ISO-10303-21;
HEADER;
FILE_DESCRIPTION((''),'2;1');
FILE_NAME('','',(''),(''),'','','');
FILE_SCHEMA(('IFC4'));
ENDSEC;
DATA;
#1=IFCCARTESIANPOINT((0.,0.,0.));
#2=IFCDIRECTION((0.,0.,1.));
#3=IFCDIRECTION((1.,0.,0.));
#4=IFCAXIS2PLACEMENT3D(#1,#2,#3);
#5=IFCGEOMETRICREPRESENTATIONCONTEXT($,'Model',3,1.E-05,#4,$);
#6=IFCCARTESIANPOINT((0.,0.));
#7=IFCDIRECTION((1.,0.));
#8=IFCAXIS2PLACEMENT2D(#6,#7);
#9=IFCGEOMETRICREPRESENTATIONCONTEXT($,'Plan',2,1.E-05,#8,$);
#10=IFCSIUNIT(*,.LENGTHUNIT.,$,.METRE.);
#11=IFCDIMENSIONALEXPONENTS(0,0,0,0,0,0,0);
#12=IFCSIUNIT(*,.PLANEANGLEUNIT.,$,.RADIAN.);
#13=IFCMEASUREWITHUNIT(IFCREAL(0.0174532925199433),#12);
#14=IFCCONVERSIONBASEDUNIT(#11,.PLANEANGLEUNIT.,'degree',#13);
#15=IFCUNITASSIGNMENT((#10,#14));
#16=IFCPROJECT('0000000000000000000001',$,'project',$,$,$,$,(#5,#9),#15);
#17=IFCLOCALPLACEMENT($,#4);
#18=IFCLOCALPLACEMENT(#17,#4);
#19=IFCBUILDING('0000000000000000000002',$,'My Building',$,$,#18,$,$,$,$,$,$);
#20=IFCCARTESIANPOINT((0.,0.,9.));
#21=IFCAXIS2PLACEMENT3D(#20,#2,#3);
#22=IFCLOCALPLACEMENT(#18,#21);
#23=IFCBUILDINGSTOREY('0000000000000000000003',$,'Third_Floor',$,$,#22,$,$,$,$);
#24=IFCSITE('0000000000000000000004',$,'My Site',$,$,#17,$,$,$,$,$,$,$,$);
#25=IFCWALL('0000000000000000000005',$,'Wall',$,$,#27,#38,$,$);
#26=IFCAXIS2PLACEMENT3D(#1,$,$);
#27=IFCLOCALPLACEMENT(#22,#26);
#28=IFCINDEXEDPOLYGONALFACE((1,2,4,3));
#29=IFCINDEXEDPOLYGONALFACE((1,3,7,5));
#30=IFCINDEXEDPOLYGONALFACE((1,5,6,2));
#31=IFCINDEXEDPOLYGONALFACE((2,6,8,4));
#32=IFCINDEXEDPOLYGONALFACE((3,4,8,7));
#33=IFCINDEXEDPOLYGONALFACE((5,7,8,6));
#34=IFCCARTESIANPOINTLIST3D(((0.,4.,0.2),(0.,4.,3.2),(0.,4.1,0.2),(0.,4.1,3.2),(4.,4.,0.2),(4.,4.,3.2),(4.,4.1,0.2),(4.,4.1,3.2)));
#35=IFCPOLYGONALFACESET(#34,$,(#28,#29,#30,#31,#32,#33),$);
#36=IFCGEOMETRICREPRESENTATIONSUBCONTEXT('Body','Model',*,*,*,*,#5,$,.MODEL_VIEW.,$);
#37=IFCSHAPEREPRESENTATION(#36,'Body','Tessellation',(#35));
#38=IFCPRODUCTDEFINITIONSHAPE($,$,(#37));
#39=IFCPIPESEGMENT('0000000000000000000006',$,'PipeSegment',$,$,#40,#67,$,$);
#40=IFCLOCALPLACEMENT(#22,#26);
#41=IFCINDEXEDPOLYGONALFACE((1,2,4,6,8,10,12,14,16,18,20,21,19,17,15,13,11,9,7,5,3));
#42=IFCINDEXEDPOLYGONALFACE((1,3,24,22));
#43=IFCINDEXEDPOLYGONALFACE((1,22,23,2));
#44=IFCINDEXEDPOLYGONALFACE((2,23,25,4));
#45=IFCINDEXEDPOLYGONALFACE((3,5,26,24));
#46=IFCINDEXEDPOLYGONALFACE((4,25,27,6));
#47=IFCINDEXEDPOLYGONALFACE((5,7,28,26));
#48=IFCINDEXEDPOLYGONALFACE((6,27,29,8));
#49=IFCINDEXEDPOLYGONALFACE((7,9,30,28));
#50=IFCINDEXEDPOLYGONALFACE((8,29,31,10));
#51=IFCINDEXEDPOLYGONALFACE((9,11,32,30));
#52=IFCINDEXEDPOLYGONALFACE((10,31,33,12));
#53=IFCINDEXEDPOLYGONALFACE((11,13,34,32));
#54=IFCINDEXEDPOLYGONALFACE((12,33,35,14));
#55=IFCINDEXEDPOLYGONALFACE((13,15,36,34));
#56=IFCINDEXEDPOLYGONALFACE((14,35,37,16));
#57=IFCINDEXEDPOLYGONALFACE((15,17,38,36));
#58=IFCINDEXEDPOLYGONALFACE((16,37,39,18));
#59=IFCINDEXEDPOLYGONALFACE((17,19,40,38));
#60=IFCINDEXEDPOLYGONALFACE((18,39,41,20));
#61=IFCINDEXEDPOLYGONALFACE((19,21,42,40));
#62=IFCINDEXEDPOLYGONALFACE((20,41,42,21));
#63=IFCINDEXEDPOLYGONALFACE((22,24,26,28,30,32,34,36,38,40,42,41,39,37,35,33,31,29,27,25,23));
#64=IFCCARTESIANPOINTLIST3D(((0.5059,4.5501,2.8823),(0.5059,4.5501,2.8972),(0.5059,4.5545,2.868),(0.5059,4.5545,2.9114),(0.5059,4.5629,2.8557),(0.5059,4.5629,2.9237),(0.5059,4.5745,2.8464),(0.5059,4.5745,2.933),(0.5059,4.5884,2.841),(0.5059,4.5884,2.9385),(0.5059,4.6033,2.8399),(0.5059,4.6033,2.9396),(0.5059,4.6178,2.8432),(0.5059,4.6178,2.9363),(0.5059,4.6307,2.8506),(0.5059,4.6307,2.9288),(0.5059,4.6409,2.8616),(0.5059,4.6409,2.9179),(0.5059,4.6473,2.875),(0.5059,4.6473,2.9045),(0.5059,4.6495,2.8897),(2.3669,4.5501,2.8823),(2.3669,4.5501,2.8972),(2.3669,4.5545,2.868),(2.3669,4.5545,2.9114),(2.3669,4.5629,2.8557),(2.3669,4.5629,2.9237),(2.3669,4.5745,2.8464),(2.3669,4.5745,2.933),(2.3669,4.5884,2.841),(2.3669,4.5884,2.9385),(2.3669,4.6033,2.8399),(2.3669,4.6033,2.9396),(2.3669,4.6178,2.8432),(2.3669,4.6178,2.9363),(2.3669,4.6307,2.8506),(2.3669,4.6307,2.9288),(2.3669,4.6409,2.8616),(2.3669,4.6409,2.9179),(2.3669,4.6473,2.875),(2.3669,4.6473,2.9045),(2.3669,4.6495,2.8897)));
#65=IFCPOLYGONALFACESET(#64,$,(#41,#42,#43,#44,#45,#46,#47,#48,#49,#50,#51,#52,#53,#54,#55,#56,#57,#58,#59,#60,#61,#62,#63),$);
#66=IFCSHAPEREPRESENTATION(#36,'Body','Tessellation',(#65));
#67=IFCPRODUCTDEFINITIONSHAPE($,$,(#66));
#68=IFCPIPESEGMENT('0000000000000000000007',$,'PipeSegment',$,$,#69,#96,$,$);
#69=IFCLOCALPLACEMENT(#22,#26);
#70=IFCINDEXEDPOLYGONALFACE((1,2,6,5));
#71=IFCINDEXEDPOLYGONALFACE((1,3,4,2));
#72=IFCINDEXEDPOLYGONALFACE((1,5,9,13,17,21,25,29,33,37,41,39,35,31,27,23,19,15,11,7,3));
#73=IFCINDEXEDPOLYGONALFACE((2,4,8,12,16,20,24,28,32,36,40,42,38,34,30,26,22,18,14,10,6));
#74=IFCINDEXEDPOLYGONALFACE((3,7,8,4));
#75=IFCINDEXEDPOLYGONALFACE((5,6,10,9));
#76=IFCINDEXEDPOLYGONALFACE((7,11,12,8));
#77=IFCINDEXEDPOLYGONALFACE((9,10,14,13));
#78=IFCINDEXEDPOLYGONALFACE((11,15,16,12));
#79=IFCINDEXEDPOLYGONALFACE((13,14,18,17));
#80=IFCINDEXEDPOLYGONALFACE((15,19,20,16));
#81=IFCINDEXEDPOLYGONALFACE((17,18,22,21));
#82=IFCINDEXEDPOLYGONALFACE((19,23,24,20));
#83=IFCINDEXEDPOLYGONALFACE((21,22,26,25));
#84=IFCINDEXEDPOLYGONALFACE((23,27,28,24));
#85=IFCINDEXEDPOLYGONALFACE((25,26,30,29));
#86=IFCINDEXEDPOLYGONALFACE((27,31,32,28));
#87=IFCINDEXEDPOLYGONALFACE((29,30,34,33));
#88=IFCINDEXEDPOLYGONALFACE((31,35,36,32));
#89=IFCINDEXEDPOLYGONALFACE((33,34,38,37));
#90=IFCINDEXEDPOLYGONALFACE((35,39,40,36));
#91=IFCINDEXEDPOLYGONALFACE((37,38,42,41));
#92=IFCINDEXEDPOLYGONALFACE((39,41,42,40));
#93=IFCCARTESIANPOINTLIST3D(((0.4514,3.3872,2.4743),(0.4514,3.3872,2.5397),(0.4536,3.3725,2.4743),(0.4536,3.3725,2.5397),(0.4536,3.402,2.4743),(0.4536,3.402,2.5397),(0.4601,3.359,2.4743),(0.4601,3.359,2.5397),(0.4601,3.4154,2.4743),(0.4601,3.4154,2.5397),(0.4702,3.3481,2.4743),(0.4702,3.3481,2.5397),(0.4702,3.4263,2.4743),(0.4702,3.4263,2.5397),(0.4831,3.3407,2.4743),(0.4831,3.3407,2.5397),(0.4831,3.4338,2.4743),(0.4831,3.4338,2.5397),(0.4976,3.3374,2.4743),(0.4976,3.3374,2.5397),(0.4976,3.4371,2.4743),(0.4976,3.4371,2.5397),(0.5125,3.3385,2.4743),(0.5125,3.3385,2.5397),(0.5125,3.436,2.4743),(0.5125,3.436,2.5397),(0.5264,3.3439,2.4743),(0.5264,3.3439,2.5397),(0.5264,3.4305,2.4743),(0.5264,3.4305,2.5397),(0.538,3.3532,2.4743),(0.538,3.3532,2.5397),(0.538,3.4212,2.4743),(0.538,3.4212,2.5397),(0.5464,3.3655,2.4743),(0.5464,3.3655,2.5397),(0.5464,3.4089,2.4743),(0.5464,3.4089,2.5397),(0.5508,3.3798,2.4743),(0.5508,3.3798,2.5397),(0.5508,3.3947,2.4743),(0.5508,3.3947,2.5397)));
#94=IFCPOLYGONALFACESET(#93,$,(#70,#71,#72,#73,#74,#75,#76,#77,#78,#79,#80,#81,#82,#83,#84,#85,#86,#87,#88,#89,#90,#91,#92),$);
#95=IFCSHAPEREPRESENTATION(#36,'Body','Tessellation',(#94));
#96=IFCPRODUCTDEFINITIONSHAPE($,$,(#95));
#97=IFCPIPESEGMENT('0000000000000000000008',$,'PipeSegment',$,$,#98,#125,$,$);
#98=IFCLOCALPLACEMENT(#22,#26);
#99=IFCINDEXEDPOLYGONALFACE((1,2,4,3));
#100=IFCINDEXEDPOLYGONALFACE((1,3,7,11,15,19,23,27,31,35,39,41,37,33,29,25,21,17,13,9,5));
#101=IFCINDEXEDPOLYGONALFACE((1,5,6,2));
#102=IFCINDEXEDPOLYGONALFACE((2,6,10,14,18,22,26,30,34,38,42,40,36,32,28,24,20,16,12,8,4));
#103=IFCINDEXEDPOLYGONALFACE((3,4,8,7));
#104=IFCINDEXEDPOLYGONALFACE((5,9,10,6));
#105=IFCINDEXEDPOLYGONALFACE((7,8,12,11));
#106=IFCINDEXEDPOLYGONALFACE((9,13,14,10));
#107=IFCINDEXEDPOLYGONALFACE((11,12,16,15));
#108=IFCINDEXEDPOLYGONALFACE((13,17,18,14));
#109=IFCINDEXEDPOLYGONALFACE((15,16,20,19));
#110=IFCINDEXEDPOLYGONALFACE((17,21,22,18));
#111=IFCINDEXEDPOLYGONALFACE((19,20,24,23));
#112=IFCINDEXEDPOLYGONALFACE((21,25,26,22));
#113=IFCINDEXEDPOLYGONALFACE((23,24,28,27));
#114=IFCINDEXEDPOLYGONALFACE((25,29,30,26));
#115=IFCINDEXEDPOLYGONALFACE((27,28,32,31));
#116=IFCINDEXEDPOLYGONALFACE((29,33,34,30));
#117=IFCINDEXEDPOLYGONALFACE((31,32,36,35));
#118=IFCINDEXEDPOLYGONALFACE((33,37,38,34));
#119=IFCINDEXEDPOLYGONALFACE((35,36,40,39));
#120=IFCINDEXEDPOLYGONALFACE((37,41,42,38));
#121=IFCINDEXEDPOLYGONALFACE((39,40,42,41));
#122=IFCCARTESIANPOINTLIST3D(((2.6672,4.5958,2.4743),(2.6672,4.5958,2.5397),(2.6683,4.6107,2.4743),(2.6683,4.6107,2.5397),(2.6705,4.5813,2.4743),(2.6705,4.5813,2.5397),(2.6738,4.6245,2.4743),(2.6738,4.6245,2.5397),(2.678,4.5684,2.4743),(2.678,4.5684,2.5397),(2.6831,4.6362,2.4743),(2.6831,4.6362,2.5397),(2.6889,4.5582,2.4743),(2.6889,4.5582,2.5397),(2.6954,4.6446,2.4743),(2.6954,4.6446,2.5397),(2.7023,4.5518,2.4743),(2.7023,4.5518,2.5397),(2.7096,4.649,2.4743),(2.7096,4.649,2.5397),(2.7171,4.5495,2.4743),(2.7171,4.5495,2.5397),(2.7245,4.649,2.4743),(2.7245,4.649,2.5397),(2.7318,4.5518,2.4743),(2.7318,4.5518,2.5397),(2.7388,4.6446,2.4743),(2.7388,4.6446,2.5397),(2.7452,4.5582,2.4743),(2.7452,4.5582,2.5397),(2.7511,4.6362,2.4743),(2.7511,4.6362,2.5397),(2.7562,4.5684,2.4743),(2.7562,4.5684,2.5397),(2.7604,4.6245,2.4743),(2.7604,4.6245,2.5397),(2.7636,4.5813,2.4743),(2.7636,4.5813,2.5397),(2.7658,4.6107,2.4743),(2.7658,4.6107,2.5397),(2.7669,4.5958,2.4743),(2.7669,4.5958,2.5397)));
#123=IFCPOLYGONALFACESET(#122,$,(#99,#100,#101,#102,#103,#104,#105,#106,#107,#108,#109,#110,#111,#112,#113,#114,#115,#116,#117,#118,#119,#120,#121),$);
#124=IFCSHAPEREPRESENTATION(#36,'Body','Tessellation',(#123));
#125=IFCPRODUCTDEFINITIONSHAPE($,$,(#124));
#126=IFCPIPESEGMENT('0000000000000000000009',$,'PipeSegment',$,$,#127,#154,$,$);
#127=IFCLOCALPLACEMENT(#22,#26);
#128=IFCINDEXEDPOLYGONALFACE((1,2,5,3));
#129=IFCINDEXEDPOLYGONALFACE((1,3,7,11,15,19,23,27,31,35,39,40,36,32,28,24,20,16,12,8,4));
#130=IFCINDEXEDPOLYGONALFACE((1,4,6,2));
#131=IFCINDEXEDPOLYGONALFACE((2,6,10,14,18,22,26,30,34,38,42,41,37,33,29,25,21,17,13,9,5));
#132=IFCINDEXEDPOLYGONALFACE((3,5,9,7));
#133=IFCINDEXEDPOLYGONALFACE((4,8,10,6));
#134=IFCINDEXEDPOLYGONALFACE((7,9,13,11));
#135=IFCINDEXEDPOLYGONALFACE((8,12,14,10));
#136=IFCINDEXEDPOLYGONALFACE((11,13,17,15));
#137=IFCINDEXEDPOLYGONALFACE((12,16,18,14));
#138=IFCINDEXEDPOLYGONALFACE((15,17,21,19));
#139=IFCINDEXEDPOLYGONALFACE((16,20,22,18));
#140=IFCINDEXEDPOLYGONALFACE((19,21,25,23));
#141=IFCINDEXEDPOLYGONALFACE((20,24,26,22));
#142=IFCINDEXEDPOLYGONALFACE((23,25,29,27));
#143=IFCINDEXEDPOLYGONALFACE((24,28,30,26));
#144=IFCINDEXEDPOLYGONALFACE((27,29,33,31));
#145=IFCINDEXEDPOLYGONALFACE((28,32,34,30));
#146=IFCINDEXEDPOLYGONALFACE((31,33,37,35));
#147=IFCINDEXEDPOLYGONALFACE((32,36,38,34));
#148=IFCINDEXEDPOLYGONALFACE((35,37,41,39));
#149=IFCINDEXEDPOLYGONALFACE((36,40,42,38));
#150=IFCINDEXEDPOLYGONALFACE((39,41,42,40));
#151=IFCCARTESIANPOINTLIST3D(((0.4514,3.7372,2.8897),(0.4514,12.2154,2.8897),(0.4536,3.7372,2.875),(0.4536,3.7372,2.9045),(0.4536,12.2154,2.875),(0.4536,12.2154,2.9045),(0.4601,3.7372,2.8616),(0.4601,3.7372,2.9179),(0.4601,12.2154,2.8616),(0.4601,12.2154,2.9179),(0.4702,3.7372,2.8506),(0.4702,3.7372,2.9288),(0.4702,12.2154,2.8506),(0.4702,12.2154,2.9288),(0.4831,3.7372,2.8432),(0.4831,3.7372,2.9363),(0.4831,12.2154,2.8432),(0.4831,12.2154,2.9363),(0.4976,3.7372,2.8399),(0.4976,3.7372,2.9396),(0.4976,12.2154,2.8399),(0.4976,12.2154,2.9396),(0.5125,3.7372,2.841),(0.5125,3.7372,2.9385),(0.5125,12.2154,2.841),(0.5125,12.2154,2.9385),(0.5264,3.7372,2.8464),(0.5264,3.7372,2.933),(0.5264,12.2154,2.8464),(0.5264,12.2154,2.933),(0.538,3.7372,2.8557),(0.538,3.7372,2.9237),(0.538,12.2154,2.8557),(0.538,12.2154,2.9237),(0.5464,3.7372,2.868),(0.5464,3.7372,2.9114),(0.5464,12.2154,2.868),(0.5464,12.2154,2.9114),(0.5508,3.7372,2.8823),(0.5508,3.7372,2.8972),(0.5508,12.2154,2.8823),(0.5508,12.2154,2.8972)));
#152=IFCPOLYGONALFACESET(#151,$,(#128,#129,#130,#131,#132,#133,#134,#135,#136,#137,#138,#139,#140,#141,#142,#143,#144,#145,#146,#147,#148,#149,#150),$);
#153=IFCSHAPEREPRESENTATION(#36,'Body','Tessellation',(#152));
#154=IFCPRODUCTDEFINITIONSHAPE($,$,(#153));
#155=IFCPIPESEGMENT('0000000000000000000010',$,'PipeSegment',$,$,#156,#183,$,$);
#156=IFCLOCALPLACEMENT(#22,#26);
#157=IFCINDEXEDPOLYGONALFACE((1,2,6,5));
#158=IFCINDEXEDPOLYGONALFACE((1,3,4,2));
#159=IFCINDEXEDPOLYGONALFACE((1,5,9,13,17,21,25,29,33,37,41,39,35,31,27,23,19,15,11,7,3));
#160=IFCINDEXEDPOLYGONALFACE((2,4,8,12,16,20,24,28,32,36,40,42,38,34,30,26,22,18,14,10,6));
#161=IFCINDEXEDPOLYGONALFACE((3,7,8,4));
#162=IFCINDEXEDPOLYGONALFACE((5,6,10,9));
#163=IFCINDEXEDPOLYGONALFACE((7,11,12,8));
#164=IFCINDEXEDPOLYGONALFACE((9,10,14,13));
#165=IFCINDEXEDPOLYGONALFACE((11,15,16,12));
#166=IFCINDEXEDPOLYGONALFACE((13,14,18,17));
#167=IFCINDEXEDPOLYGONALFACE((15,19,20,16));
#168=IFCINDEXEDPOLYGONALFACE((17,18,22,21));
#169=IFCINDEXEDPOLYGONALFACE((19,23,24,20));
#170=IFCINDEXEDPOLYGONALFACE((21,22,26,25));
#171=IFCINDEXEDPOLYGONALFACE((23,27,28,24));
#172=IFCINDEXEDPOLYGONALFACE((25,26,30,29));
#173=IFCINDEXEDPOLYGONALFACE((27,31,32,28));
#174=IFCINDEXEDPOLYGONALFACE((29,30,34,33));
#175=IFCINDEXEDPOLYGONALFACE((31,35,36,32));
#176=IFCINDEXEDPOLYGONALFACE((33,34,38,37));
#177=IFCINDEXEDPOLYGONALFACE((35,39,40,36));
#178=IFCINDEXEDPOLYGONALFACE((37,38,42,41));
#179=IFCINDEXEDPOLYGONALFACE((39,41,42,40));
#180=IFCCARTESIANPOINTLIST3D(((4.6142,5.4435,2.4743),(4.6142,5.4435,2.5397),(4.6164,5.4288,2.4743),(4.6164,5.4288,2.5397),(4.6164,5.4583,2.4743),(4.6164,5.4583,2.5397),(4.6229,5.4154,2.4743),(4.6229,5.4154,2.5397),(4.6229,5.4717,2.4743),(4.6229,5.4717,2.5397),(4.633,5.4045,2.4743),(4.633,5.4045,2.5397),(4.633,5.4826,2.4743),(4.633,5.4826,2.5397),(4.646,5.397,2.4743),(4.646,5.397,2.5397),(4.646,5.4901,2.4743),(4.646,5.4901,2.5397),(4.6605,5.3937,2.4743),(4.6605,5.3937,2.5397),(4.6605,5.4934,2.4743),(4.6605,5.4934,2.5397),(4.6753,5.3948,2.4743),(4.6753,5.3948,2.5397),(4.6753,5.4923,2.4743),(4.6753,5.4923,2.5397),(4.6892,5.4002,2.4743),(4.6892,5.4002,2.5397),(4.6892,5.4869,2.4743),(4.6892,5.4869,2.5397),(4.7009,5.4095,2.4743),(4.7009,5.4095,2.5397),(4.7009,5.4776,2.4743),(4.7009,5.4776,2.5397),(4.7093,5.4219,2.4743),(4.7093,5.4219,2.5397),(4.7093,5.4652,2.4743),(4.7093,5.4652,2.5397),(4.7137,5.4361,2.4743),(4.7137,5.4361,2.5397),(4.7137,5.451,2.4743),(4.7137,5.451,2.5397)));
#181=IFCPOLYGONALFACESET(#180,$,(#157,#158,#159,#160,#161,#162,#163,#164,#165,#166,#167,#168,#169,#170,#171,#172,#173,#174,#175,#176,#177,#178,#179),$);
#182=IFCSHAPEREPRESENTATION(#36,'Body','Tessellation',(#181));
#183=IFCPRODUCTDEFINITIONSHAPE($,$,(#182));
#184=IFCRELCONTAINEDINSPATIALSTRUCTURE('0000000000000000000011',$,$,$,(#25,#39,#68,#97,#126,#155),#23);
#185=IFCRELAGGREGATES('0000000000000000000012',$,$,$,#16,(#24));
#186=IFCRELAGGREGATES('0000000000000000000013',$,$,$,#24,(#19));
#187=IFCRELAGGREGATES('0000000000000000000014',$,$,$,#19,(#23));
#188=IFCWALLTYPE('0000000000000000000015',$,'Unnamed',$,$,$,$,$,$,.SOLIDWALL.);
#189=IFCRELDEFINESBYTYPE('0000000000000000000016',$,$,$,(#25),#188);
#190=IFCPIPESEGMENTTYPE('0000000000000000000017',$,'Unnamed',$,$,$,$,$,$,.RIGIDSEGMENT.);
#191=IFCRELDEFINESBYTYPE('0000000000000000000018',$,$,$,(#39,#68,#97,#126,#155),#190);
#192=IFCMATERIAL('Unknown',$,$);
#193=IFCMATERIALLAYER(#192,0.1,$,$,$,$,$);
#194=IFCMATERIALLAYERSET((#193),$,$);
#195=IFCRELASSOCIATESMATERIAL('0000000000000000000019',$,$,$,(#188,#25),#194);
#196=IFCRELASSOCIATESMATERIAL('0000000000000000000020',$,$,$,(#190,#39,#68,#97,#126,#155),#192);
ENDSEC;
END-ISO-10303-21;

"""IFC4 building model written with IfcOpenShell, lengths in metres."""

from ifc_helpers import new_model, entity, si_unit, converted_unit, frame, origin_with_axes, origin_2d_with_axis, place, context, subcontext, project, spatial, line, indexed_curve, circle, outline, extrude, material, layer, layer_set, layer_usage, material_profile, profile_set, profile_usage, type_object, element, save


model = new_model("IFC4")

# Units and contexts
model_context = context("Model", 3, precision=1e-05, world=origin_with_axes())
plan_context = context("Plan", 2, precision=1e-05, world=origin_2d_with_axis())
body_context_1 = subcontext(model_context, "Body", "Model", "MODEL_VIEW")
ifc_project = project(units=[si_unit("LENGTHUNIT", "METRE"), converted_unit("PLANEANGLEUNIT", "degree", entity("IfcReal", 0.0174532925199433), si_unit("PLANEANGLEUNIT", "RADIAN"), dimensions=[0, 0, 0, 0, 0, 0, 0])], contexts=[model_context, plan_context])

# Site, building, storey
site_placement = place(None, origin_with_axes())
site = spatial("IfcSite", under=ifc_project, at=site_placement, Name="My Site")
building_placement = place(site_placement, origin_with_axes())
building = spatial("IfcBuilding", under=site, at=building_placement, Name="My Building")
storey_placement = place(building_placement, frame((0.0, 0.0, 9.0), z_axis=(0.0, 0.0, 1.0), x_axis=(1.0, 0.0, 0.0)))
storey = spatial("IfcBuildingStorey", under=building, at=storey_placement, Name="Third_Floor")

# Wall
ifc_material = material(Name="Unknown")
ifc_layer = layer(ifc_material, 0.1)
ifc_layer_set = layer_set([ifc_layer])
ifc_layer_usage_1 = layer_usage(ifc_layer_set, "AXIS2", "POSITIVE", 0.0)
wall_type = type_object("IfcWallType", Name="Unnamed", PredefinedType="SOLIDWALL", material=ifc_layer_set)
wall_1_placement = place(storey_placement, frame((0.0, 4.0, 0.2), z_axis=(0.0, 0.0, 1.0), x_axis=(1.0, 0.0, 0.0)))
element("IfcWall", 1, at=wall_1_placement, inside=storey, type_object=wall_type, material=ifc_layer_usage_1, Name="Wall", context=body_context_1, shape_type="SweptSolid", body=[
    extrude(outline(indexed_curve([(0.0, 0.0), (0.0, 0.1), (4.0, 0.1), (4.0, 0.0)], segments=[line(1, 2, 3, 4, 1)])), origin_with_axes(), (0.0, 0.0, 1.0), 3.0),
])

# Pipe segments
ifc_material_profile = material_profile(ifc_material, circle(Radius=0.05))
ifc_profile_set = profile_set([ifc_material_profile])
ifc_profile_usage_1 = profile_usage(ifc_profile_set, cardinal=5)
pipe_segment_type = type_object("IfcPipeSegmentType", Name="Unnamed", PredefinedType="RIGIDSEGMENT", material=ifc_profile_set)
pipe_segment_1_placement = place(storey_placement, frame((0.5059, 4.5995, 2.8897), z_axis=(1.0, 0.0, 0.0), x_axis=(0.0, 1.0, 0.0)))
element("IfcPipeSegment", 2, at=pipe_segment_1_placement, inside=storey, type_object=pipe_segment_type, material=ifc_profile_usage_1, Name="PipeSegment", context=body_context_1, shape_type="SweptSolid", body=[
    extrude(circle(Radius=0.05), origin_with_axes(), (0.0, 0.0, 1.0), 1.861),
])
ifc_profile_usage_2 = profile_usage(ifc_profile_set, cardinal=5)
pipe_segment_2_placement = place(storey_placement, frame((0.5014, 3.3872, 2.4743), z_axis=(0.0, 0.0, 1.0), x_axis=(-1.0, 0.0, 0.0)))
element("IfcPipeSegment", 3, at=pipe_segment_2_placement, inside=storey, type_object=pipe_segment_type, material=ifc_profile_usage_2, Name="PipeSegment", context=body_context_1, shape_type="SweptSolid", body=[
    extrude(circle(Radius=0.05), origin_with_axes(), (0.0, 0.0, 1.0), 0.0654),
])
ifc_profile_usage_3 = profile_usage(ifc_profile_set, cardinal=5)
pipe_segment_3_placement = place(storey_placement, frame((2.7171, 4.5995, 2.4743), z_axis=(0.0, 0.0, 1.0), x_axis=(0.000001, -1.0, 0.0)))
element("IfcPipeSegment", 4, at=pipe_segment_3_placement, inside=storey, type_object=pipe_segment_type, material=ifc_profile_usage_3, Name="PipeSegment", context=body_context_1, shape_type="SweptSolid", body=[
    extrude(circle(Radius=0.05), origin_with_axes(), (0.0, 0.0, 1.0), 0.0654),
])
ifc_profile_usage_4 = profile_usage(ifc_profile_set, cardinal=5)
pipe_segment_4_placement = place(storey_placement, frame((0.5014, 3.7372, 2.8897), z_axis=(0.0, 1.0, 0.0), x_axis=(-1.0, 0.0, 0.0)))
element("IfcPipeSegment", 5, at=pipe_segment_4_placement, inside=storey, type_object=pipe_segment_type, material=ifc_profile_usage_4, Name="PipeSegment", context=body_context_1, shape_type="SweptSolid", body=[
    extrude(circle(Radius=0.05), origin_with_axes(), (0.0, 0.0, 1.0), 8.4782),
])
ifc_profile_usage_5 = profile_usage(ifc_profile_set, cardinal=5)
pipe_segment_5_placement = place(storey_placement, frame((4.6642, 5.4435, 2.4743), z_axis=(0.0, 0.0, 1.0), x_axis=(-1.0, 0.0, 0.0)))
element("IfcPipeSegment", 6, at=pipe_segment_5_placement, inside=storey, type_object=pipe_segment_type, material=ifc_profile_usage_5, Name="PipeSegment", context=body_context_1, shape_type="SweptSolid", body=[
    extrude(circle(Radius=0.05), origin_with_axes(), (0.0, 0.0, 1.0), 0.0654),
])

save(model, "model.ifc")
